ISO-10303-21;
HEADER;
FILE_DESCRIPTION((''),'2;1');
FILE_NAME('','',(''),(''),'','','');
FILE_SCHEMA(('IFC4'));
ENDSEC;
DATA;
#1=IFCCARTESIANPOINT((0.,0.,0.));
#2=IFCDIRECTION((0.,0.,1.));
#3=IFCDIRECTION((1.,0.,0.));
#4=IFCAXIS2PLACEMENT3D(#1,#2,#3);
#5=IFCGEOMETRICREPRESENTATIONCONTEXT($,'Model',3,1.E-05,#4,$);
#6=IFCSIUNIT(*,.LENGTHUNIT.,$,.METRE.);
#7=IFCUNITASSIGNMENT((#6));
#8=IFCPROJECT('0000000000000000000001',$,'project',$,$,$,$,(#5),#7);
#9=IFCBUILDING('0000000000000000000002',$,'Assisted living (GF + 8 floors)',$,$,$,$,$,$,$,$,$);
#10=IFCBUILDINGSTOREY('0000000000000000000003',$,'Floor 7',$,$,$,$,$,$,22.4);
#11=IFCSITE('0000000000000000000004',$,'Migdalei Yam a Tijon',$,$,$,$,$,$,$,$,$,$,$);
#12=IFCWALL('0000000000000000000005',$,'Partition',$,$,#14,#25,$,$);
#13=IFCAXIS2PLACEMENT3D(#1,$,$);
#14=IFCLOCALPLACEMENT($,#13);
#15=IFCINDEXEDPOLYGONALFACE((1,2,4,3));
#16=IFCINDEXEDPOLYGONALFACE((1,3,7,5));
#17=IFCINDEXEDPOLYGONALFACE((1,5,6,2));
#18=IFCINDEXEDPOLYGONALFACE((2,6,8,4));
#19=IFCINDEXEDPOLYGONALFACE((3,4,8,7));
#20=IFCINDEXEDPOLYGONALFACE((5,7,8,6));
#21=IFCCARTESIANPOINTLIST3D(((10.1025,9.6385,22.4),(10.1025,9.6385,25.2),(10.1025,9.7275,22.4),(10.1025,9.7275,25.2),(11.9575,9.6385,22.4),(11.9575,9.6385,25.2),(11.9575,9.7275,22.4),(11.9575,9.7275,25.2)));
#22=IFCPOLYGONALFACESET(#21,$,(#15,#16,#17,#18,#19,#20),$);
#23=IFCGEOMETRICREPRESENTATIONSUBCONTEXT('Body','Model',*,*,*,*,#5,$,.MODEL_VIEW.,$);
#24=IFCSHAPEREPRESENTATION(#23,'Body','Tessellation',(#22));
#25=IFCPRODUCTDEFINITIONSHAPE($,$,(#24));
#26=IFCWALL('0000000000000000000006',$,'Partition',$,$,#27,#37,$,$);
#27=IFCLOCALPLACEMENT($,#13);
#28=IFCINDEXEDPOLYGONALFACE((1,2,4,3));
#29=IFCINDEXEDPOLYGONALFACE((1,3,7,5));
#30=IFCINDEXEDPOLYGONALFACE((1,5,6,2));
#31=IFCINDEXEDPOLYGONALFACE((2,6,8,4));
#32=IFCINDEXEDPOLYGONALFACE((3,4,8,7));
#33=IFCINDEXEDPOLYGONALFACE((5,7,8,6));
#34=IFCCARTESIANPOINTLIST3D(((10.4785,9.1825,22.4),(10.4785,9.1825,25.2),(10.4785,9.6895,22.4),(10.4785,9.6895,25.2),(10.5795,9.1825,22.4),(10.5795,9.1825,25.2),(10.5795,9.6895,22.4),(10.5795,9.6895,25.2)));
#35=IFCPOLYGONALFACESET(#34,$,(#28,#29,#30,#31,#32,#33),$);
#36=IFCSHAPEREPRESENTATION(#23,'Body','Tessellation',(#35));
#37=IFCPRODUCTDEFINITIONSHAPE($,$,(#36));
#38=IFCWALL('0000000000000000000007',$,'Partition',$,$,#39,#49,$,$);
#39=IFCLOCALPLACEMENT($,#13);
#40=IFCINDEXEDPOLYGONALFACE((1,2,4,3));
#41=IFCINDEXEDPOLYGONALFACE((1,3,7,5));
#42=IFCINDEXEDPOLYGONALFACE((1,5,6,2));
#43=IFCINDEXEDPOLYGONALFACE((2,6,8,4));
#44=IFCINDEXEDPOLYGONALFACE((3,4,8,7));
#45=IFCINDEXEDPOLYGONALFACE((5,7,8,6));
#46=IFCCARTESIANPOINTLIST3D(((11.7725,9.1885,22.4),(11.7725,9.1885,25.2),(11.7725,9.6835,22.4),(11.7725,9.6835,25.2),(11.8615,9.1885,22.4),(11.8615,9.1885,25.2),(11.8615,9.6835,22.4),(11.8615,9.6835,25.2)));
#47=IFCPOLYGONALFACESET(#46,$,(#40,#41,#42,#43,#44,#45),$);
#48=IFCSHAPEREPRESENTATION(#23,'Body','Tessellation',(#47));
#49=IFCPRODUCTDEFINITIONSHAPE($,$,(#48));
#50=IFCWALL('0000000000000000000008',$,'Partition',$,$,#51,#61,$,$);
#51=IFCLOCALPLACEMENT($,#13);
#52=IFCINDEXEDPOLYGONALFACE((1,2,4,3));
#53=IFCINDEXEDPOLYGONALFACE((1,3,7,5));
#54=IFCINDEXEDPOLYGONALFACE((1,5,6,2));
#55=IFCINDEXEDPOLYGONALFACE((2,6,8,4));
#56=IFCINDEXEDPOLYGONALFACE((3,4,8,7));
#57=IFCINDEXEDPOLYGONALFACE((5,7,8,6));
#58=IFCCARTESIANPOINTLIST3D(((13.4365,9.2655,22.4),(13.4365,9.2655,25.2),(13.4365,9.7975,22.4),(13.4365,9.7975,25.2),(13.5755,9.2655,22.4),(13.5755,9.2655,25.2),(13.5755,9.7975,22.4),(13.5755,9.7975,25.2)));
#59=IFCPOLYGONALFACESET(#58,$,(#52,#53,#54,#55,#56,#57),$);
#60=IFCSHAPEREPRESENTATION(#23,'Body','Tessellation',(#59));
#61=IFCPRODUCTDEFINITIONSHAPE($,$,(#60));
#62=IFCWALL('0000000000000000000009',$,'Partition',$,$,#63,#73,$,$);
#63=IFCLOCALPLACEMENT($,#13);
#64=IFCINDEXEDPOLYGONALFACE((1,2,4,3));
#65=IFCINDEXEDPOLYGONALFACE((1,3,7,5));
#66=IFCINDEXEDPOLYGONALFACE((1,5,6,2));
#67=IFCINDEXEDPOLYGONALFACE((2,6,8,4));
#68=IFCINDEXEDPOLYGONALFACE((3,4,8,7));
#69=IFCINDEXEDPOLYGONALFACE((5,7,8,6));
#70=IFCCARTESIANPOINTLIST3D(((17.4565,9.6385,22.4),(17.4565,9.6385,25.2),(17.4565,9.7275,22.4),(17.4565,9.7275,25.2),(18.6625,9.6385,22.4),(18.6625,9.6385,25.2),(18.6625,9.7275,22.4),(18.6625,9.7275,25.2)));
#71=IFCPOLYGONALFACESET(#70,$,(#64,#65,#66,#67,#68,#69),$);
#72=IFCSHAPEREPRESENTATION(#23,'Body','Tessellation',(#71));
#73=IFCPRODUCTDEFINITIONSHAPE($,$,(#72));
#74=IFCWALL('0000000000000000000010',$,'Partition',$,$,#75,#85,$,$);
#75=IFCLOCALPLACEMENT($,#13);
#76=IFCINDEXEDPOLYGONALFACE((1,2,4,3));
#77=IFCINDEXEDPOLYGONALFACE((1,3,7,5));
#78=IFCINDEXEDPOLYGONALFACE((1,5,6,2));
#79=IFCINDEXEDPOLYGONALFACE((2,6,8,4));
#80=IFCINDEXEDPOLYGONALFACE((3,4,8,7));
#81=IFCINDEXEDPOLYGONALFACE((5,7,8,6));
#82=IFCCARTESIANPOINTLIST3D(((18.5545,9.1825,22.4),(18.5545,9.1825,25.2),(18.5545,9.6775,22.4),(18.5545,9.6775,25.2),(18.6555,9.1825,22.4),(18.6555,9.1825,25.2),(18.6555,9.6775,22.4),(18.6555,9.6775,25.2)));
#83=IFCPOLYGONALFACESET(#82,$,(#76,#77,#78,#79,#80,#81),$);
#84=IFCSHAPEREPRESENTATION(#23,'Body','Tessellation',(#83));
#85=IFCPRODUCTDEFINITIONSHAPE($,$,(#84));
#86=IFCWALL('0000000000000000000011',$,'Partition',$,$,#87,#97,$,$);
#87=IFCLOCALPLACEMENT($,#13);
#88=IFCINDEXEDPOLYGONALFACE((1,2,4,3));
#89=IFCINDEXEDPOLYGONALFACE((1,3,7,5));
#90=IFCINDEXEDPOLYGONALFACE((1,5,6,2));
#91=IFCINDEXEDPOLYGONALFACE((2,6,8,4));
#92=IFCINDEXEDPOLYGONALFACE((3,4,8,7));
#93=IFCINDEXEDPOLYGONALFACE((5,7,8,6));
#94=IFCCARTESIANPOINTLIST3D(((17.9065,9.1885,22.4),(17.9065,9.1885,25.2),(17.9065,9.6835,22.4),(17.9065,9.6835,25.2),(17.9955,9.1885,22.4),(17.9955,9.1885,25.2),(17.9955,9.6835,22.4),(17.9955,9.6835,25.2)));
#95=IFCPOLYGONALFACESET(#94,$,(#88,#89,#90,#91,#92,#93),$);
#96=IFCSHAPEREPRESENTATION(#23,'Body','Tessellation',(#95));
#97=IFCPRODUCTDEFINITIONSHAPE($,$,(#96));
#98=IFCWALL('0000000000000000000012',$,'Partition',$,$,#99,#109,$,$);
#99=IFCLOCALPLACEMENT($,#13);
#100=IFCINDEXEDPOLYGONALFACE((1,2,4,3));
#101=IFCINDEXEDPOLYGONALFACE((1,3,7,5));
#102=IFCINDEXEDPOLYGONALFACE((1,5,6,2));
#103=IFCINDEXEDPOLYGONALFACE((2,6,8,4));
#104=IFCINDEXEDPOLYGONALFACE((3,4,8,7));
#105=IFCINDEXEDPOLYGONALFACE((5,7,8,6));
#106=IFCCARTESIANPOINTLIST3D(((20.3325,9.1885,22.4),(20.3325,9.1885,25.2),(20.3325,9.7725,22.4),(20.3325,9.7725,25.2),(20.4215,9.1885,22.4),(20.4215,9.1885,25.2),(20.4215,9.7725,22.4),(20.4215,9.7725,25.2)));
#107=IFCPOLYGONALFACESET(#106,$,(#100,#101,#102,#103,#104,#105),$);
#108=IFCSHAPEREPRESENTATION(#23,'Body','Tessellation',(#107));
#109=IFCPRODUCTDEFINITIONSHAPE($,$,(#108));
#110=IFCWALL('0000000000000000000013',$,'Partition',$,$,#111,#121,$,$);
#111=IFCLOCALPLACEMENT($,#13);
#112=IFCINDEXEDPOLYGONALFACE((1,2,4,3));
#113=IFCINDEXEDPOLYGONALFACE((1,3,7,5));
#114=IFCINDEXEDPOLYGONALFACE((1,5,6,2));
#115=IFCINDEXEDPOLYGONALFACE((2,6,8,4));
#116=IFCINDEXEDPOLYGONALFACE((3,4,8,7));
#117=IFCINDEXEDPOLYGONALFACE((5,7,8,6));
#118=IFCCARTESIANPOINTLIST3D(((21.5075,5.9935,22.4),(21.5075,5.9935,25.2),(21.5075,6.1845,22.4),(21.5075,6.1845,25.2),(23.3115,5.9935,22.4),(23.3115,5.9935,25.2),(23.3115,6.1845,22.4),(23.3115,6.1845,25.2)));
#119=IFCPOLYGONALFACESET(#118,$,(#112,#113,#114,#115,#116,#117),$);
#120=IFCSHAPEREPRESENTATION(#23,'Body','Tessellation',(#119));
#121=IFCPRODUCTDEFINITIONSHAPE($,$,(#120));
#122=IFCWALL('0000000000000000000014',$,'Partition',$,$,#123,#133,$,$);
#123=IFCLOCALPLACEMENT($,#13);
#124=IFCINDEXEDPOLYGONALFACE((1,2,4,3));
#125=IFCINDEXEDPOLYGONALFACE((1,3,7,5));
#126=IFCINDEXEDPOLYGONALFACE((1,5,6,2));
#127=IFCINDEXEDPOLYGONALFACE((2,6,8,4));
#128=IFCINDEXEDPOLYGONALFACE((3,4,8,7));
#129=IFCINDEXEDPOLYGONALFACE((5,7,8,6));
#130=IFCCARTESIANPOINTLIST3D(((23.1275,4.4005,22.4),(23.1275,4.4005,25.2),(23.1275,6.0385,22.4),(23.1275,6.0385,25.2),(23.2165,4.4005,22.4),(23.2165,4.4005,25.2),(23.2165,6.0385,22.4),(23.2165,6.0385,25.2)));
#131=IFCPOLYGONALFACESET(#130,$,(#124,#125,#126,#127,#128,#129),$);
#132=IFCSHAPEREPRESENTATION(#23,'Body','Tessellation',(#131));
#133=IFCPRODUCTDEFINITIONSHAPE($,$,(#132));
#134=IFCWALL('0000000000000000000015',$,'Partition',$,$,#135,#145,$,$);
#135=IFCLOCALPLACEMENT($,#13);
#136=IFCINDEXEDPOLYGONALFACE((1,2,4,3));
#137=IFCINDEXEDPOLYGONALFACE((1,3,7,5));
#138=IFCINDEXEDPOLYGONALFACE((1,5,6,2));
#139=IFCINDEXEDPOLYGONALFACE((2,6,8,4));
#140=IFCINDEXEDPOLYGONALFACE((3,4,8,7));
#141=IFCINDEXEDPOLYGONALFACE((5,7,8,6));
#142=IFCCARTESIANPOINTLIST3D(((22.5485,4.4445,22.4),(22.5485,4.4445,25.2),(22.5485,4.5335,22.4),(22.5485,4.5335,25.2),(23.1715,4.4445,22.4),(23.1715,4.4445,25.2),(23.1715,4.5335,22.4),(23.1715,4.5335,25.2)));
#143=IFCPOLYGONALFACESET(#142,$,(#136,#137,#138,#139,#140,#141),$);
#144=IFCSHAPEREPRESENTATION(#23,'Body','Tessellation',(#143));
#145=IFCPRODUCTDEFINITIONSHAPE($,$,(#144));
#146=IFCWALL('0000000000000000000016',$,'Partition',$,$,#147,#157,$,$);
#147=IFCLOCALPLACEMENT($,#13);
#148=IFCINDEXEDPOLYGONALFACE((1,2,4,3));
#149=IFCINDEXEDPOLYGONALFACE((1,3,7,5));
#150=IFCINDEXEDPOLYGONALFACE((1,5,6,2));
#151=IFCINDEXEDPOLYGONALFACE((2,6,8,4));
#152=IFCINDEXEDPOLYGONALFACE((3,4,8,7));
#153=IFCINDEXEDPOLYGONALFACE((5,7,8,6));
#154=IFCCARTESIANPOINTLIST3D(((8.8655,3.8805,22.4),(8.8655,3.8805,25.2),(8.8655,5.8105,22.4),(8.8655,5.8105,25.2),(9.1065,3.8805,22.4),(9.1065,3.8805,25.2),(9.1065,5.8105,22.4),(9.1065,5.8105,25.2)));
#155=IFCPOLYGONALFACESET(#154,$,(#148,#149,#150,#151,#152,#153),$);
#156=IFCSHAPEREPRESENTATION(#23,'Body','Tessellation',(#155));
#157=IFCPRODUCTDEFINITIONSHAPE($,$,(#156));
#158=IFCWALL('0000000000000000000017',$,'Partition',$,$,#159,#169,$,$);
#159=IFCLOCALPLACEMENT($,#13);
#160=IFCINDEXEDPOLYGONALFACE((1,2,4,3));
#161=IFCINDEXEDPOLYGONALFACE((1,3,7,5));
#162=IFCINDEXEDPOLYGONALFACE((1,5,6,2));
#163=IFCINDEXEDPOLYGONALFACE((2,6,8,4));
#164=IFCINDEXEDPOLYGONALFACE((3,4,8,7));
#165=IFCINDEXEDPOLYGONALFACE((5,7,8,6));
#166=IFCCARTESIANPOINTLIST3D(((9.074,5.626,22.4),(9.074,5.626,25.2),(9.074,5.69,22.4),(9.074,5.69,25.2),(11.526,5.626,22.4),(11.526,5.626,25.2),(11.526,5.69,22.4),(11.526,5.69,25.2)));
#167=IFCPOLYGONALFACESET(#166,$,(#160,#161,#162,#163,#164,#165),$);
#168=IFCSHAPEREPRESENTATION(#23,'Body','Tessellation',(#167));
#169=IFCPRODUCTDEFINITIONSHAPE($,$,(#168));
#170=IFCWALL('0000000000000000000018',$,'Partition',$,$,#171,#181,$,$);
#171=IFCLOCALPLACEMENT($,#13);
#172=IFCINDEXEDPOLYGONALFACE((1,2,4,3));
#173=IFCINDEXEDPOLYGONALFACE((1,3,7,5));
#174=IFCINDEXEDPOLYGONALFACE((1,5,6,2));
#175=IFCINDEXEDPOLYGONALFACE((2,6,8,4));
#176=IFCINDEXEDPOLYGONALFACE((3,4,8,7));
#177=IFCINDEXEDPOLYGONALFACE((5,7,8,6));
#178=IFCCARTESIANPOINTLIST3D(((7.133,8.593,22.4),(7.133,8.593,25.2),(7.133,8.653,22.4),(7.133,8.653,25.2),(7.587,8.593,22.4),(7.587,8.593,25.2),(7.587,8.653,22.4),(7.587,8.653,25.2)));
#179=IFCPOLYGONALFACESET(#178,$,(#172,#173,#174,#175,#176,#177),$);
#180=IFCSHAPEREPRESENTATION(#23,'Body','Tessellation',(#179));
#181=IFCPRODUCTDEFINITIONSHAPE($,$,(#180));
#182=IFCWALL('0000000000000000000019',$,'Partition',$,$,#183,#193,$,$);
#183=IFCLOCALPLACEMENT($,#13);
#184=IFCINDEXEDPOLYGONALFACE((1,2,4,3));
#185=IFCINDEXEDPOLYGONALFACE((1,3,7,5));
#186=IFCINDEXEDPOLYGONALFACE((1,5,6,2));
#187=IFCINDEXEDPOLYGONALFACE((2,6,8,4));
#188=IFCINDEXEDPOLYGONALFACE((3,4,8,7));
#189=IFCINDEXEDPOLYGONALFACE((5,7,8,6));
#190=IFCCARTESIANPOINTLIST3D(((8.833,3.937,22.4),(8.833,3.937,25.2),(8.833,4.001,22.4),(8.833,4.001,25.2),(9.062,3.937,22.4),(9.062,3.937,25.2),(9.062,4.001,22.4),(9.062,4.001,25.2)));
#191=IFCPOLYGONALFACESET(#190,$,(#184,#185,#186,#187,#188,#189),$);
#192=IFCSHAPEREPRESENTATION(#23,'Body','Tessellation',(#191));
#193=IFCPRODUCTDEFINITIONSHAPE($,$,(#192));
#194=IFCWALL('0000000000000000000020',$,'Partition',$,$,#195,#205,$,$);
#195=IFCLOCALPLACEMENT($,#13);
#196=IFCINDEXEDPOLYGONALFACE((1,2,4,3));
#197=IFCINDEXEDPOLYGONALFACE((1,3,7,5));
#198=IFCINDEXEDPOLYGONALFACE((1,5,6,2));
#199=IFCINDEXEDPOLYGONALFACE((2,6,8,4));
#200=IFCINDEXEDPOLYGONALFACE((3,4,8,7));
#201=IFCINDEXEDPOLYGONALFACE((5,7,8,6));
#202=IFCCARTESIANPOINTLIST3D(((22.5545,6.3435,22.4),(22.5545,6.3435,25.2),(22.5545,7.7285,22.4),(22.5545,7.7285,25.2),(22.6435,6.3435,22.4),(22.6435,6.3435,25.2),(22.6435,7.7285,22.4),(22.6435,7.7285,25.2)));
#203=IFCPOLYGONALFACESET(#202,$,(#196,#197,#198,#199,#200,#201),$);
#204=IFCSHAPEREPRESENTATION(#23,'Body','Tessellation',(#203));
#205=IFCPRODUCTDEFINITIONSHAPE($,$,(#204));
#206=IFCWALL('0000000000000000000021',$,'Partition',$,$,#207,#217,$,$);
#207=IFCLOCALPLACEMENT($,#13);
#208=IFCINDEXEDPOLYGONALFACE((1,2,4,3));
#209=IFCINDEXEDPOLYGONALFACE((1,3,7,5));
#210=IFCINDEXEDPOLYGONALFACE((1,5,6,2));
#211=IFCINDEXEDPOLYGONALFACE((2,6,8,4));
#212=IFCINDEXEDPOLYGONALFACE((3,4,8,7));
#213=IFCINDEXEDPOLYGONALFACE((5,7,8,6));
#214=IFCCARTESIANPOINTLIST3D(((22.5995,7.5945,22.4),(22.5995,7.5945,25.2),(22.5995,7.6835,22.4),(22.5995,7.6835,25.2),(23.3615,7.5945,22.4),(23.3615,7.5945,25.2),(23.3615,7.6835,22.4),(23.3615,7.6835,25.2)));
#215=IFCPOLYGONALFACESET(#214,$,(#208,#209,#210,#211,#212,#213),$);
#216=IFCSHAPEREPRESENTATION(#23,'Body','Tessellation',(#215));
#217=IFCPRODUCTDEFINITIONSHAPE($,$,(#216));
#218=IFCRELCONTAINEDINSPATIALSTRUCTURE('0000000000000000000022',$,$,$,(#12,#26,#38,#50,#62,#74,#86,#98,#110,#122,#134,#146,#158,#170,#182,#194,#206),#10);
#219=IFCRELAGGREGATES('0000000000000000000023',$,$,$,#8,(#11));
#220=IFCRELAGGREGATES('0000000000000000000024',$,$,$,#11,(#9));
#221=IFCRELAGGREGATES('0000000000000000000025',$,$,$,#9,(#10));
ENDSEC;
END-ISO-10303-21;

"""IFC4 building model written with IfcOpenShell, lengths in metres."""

from ifc_helpers import new_model, si_unit, frame, origin_with_axes, context, subcontext, project, spatial, line, indexed_curve, outline, extrude, element, save


model = new_model("IFC4")

# Units and contexts
model_context = context("Model", 3, precision=1e-05, world=origin_with_axes())
body_context = subcontext(model_context, "Body", "Model", "MODEL_VIEW")
ifc_project = project(units=[si_unit("LENGTHUNIT", "METRE")], contexts=[model_context])

# Site, building, storey
site = spatial("IfcSite", under=ifc_project, Name="Migdalei Yam a Tijon")
building = spatial("IfcBuilding", under=site, Name="Assisted living (GF + 8 floors)")
storey = spatial("IfcBuildingStorey", under=building, Name="Floor 7", Elevation=22.4)

# Walls
element("IfcWall", 1, inside=storey, Name="Partition", context=body_context, shape_type="SweptSolid", body=[
    extrude(outline(indexed_curve([(0.0, 0.0), (1.855, 0.0), (1.855, 0.089), (0.0, 0.089)], segments=[line(1, 2, 3, 4, 1)])), frame((10.1025, 9.6385, 22.4), z_axis=(0.0, 0.0, 1.0), x_axis=(1.0, 0.0, 0.0)), (0.0, 0.0, 1.0), 2.8),
])
element("IfcWall", 2, inside=storey, Name="Partition", context=body_context, shape_type="SweptSolid", body=[
    extrude(outline(indexed_curve([(0.0, 0.0), (0.101, 0.0), (0.101, 0.507), (0.0, 0.507)], segments=[line(1, 2, 3, 4, 1)])), frame((10.4785, 9.1825, 22.4), z_axis=(0.0, 0.0, 1.0), x_axis=(1.0, 0.0, 0.0)), (0.0, 0.0, 1.0), 2.8),
])
element("IfcWall", 3, inside=storey, Name="Partition", context=body_context, shape_type="SweptSolid", body=[
    extrude(outline(indexed_curve([(0.0, 0.0), (0.089, 0.0), (0.089, 0.495), (0.0, 0.495)], segments=[line(1, 2, 3, 4, 1)])), frame((11.7725, 9.1885, 22.4), z_axis=(0.0, 0.0, 1.0), x_axis=(1.0, 0.0, 0.0)), (0.0, 0.0, 1.0), 2.8),
])
element("IfcWall", 4, inside=storey, Name="Partition", context=body_context, shape_type="SweptSolid", body=[
    extrude(outline(indexed_curve([(0.0, 0.0), (0.139, 0.0), (0.139, 0.532), (0.0, 0.532)], segments=[line(1, 2, 3, 4, 1)])), frame((13.4365, 9.2655, 22.4), z_axis=(0.0, 0.0, 1.0), x_axis=(1.0, 0.0, 0.0)), (0.0, 0.0, 1.0), 2.8),
])
element("IfcWall", 5, inside=storey, Name="Partition", context=body_context, shape_type="SweptSolid", body=[
    extrude(outline(indexed_curve([(0.0, 0.0), (1.206, 0.0), (1.206, 0.089), (0.0, 0.089)], segments=[line(1, 2, 3, 4, 1)])), frame((17.4565, 9.6385, 22.4), z_axis=(0.0, 0.0, 1.0), x_axis=(1.0, 0.0, 0.0)), (0.0, 0.0, 1.0), 2.8),
])
element("IfcWall", 6, inside=storey, Name="Partition", context=body_context, shape_type="SweptSolid", body=[
    extrude(outline(indexed_curve([(0.0, 0.0), (0.101, 0.0), (0.101, 0.495), (0.0, 0.495)], segments=[line(1, 2, 3, 4, 1)])), frame((18.5545, 9.1825, 22.4), z_axis=(0.0, 0.0, 1.0), x_axis=(1.0, 0.0, 0.0)), (0.0, 0.0, 1.0), 2.8),
])
element("IfcWall", 7, inside=storey, Name="Partition", context=body_context, shape_type="SweptSolid", body=[
    extrude(outline(indexed_curve([(0.0, 0.0), (0.089, 0.0), (0.089, 0.495), (0.0, 0.495)], segments=[line(1, 2, 3, 4, 1)])), frame((17.9065, 9.1885, 22.4), z_axis=(0.0, 0.0, 1.0), x_axis=(1.0, 0.0, 0.0)), (0.0, 0.0, 1.0), 2.8),
])
element("IfcWall", 8, inside=storey, Name="Partition", context=body_context, shape_type="SweptSolid", body=[
    extrude(outline(indexed_curve([(0.0, 0.0), (0.089, 0.0), (0.089, 0.584), (0.0, 0.584)], segments=[line(1, 2, 3, 4, 1)])), frame((20.3325, 9.1885, 22.4), z_axis=(0.0, 0.0, 1.0), x_axis=(1.0, 0.0, 0.0)), (0.0, 0.0, 1.0), 2.8),
])
element("IfcWall", 9, inside=storey, Name="Partition", context=body_context, shape_type="SweptSolid", body=[
    extrude(outline(indexed_curve([(0.0, 0.0), (1.804, 0.0), (1.804, 0.191), (0.0, 0.191)], segments=[line(1, 2, 3, 4, 1)])), frame((21.5075, 5.9935, 22.4), z_axis=(0.0, 0.0, 1.0), x_axis=(1.0, 0.0, 0.0)), (0.0, 0.0, 1.0), 2.8),
])
element("IfcWall", 10, inside=storey, Name="Partition", context=body_context, shape_type="SweptSolid", body=[
    extrude(outline(indexed_curve([(0.0, 0.0), (0.089, 0.0), (0.089, 1.638), (0.0, 1.638)], segments=[line(1, 2, 3, 4, 1)])), frame((23.1275, 4.4005, 22.4), z_axis=(0.0, 0.0, 1.0), x_axis=(1.0, 0.0, 0.0)), (0.0, 0.0, 1.0), 2.8),
])
element("IfcWall", 11, inside=storey, Name="Partition", context=body_context, shape_type="SweptSolid", body=[
    extrude(outline(indexed_curve([(0.0, 0.0), (0.623, 0.0), (0.623, 0.089), (0.0, 0.089)], segments=[line(1, 2, 3, 4, 1)])), frame((22.5485, 4.4445, 22.4), z_axis=(0.0, 0.0, 1.0), x_axis=(1.0, 0.0, 0.0)), (0.0, 0.0, 1.0), 2.8),
])
element("IfcWall", 12, inside=storey, Name="Partition", context=body_context, shape_type="SweptSolid", body=[
    extrude(outline(indexed_curve([(0.0, 0.0), (0.241, 0.0), (0.241, 1.93), (0.0, 1.93)], segments=[line(1, 2, 3, 4, 1)])), frame((8.8655, 3.8805, 22.4), z_axis=(0.0, 0.0, 1.0), x_axis=(1.0, 0.0, 0.0)), (0.0, 0.0, 1.0), 2.8),
])
element("IfcWall", 13, inside=storey, Name="Partition", context=body_context, shape_type="SweptSolid", body=[
    extrude(outline(indexed_curve([(0.0, 0.0), (2.452, 0.0), (2.452, 0.064), (0.0, 0.064)], segments=[line(1, 2, 3, 4, 1)])), frame((9.074, 5.626, 22.4), z_axis=(0.0, 0.0, 1.0), x_axis=(1.0, 0.0, 0.0)), (0.0, 0.0, 1.0), 2.8),
])
element("IfcWall", 14, inside=storey, Name="Partition", context=body_context, shape_type="SweptSolid", body=[
    extrude(outline(indexed_curve([(0.0, 0.0), (0.454, 0.0), (0.454, 0.06), (0.0, 0.06)], segments=[line(1, 2, 3, 4, 1)])), frame((7.133, 8.593, 22.4), z_axis=(0.0, 0.0, 1.0), x_axis=(1.0, 0.0, 0.0)), (0.0, 0.0, 1.0), 2.8),
])
element("IfcWall", 15, inside=storey, Name="Partition", context=body_context, shape_type="SweptSolid", body=[
    extrude(outline(indexed_curve([(0.0, 0.0), (0.229, 0.0), (0.229, 0.064), (0.0, 0.064)], segments=[line(1, 2, 3, 4, 1)])), frame((8.833, 3.937, 22.4), z_axis=(0.0, 0.0, 1.0), x_axis=(1.0, 0.0, 0.0)), (0.0, 0.0, 1.0), 2.8),
])
element("IfcWall", 16, inside=storey, Name="Partition", context=body_context, shape_type="SweptSolid", body=[
    extrude(outline(indexed_curve([(0.0, 0.0), (0.089, 0.0), (0.089, 1.385), (0.0, 1.385)], segments=[line(1, 2, 3, 4, 1)])), frame((22.5545, 6.3435, 22.4), z_axis=(0.0, 0.0, 1.0), x_axis=(1.0, 0.0, 0.0)), (0.0, 0.0, 1.0), 2.8),
])
element("IfcWall", 17, inside=storey, Name="Partition", context=body_context, shape_type="SweptSolid", body=[
    extrude(outline(indexed_curve([(0.0, 0.0), (0.762, 0.0), (0.762, 0.089), (0.0, 0.089)], segments=[line(1, 2, 3, 4, 1)])), frame((22.5995, 7.5945, 22.4), z_axis=(0.0, 0.0, 1.0), x_axis=(1.0, 0.0, 0.0)), (0.0, 0.0, 1.0), 2.8),
])

save(model, "model.ifc")
